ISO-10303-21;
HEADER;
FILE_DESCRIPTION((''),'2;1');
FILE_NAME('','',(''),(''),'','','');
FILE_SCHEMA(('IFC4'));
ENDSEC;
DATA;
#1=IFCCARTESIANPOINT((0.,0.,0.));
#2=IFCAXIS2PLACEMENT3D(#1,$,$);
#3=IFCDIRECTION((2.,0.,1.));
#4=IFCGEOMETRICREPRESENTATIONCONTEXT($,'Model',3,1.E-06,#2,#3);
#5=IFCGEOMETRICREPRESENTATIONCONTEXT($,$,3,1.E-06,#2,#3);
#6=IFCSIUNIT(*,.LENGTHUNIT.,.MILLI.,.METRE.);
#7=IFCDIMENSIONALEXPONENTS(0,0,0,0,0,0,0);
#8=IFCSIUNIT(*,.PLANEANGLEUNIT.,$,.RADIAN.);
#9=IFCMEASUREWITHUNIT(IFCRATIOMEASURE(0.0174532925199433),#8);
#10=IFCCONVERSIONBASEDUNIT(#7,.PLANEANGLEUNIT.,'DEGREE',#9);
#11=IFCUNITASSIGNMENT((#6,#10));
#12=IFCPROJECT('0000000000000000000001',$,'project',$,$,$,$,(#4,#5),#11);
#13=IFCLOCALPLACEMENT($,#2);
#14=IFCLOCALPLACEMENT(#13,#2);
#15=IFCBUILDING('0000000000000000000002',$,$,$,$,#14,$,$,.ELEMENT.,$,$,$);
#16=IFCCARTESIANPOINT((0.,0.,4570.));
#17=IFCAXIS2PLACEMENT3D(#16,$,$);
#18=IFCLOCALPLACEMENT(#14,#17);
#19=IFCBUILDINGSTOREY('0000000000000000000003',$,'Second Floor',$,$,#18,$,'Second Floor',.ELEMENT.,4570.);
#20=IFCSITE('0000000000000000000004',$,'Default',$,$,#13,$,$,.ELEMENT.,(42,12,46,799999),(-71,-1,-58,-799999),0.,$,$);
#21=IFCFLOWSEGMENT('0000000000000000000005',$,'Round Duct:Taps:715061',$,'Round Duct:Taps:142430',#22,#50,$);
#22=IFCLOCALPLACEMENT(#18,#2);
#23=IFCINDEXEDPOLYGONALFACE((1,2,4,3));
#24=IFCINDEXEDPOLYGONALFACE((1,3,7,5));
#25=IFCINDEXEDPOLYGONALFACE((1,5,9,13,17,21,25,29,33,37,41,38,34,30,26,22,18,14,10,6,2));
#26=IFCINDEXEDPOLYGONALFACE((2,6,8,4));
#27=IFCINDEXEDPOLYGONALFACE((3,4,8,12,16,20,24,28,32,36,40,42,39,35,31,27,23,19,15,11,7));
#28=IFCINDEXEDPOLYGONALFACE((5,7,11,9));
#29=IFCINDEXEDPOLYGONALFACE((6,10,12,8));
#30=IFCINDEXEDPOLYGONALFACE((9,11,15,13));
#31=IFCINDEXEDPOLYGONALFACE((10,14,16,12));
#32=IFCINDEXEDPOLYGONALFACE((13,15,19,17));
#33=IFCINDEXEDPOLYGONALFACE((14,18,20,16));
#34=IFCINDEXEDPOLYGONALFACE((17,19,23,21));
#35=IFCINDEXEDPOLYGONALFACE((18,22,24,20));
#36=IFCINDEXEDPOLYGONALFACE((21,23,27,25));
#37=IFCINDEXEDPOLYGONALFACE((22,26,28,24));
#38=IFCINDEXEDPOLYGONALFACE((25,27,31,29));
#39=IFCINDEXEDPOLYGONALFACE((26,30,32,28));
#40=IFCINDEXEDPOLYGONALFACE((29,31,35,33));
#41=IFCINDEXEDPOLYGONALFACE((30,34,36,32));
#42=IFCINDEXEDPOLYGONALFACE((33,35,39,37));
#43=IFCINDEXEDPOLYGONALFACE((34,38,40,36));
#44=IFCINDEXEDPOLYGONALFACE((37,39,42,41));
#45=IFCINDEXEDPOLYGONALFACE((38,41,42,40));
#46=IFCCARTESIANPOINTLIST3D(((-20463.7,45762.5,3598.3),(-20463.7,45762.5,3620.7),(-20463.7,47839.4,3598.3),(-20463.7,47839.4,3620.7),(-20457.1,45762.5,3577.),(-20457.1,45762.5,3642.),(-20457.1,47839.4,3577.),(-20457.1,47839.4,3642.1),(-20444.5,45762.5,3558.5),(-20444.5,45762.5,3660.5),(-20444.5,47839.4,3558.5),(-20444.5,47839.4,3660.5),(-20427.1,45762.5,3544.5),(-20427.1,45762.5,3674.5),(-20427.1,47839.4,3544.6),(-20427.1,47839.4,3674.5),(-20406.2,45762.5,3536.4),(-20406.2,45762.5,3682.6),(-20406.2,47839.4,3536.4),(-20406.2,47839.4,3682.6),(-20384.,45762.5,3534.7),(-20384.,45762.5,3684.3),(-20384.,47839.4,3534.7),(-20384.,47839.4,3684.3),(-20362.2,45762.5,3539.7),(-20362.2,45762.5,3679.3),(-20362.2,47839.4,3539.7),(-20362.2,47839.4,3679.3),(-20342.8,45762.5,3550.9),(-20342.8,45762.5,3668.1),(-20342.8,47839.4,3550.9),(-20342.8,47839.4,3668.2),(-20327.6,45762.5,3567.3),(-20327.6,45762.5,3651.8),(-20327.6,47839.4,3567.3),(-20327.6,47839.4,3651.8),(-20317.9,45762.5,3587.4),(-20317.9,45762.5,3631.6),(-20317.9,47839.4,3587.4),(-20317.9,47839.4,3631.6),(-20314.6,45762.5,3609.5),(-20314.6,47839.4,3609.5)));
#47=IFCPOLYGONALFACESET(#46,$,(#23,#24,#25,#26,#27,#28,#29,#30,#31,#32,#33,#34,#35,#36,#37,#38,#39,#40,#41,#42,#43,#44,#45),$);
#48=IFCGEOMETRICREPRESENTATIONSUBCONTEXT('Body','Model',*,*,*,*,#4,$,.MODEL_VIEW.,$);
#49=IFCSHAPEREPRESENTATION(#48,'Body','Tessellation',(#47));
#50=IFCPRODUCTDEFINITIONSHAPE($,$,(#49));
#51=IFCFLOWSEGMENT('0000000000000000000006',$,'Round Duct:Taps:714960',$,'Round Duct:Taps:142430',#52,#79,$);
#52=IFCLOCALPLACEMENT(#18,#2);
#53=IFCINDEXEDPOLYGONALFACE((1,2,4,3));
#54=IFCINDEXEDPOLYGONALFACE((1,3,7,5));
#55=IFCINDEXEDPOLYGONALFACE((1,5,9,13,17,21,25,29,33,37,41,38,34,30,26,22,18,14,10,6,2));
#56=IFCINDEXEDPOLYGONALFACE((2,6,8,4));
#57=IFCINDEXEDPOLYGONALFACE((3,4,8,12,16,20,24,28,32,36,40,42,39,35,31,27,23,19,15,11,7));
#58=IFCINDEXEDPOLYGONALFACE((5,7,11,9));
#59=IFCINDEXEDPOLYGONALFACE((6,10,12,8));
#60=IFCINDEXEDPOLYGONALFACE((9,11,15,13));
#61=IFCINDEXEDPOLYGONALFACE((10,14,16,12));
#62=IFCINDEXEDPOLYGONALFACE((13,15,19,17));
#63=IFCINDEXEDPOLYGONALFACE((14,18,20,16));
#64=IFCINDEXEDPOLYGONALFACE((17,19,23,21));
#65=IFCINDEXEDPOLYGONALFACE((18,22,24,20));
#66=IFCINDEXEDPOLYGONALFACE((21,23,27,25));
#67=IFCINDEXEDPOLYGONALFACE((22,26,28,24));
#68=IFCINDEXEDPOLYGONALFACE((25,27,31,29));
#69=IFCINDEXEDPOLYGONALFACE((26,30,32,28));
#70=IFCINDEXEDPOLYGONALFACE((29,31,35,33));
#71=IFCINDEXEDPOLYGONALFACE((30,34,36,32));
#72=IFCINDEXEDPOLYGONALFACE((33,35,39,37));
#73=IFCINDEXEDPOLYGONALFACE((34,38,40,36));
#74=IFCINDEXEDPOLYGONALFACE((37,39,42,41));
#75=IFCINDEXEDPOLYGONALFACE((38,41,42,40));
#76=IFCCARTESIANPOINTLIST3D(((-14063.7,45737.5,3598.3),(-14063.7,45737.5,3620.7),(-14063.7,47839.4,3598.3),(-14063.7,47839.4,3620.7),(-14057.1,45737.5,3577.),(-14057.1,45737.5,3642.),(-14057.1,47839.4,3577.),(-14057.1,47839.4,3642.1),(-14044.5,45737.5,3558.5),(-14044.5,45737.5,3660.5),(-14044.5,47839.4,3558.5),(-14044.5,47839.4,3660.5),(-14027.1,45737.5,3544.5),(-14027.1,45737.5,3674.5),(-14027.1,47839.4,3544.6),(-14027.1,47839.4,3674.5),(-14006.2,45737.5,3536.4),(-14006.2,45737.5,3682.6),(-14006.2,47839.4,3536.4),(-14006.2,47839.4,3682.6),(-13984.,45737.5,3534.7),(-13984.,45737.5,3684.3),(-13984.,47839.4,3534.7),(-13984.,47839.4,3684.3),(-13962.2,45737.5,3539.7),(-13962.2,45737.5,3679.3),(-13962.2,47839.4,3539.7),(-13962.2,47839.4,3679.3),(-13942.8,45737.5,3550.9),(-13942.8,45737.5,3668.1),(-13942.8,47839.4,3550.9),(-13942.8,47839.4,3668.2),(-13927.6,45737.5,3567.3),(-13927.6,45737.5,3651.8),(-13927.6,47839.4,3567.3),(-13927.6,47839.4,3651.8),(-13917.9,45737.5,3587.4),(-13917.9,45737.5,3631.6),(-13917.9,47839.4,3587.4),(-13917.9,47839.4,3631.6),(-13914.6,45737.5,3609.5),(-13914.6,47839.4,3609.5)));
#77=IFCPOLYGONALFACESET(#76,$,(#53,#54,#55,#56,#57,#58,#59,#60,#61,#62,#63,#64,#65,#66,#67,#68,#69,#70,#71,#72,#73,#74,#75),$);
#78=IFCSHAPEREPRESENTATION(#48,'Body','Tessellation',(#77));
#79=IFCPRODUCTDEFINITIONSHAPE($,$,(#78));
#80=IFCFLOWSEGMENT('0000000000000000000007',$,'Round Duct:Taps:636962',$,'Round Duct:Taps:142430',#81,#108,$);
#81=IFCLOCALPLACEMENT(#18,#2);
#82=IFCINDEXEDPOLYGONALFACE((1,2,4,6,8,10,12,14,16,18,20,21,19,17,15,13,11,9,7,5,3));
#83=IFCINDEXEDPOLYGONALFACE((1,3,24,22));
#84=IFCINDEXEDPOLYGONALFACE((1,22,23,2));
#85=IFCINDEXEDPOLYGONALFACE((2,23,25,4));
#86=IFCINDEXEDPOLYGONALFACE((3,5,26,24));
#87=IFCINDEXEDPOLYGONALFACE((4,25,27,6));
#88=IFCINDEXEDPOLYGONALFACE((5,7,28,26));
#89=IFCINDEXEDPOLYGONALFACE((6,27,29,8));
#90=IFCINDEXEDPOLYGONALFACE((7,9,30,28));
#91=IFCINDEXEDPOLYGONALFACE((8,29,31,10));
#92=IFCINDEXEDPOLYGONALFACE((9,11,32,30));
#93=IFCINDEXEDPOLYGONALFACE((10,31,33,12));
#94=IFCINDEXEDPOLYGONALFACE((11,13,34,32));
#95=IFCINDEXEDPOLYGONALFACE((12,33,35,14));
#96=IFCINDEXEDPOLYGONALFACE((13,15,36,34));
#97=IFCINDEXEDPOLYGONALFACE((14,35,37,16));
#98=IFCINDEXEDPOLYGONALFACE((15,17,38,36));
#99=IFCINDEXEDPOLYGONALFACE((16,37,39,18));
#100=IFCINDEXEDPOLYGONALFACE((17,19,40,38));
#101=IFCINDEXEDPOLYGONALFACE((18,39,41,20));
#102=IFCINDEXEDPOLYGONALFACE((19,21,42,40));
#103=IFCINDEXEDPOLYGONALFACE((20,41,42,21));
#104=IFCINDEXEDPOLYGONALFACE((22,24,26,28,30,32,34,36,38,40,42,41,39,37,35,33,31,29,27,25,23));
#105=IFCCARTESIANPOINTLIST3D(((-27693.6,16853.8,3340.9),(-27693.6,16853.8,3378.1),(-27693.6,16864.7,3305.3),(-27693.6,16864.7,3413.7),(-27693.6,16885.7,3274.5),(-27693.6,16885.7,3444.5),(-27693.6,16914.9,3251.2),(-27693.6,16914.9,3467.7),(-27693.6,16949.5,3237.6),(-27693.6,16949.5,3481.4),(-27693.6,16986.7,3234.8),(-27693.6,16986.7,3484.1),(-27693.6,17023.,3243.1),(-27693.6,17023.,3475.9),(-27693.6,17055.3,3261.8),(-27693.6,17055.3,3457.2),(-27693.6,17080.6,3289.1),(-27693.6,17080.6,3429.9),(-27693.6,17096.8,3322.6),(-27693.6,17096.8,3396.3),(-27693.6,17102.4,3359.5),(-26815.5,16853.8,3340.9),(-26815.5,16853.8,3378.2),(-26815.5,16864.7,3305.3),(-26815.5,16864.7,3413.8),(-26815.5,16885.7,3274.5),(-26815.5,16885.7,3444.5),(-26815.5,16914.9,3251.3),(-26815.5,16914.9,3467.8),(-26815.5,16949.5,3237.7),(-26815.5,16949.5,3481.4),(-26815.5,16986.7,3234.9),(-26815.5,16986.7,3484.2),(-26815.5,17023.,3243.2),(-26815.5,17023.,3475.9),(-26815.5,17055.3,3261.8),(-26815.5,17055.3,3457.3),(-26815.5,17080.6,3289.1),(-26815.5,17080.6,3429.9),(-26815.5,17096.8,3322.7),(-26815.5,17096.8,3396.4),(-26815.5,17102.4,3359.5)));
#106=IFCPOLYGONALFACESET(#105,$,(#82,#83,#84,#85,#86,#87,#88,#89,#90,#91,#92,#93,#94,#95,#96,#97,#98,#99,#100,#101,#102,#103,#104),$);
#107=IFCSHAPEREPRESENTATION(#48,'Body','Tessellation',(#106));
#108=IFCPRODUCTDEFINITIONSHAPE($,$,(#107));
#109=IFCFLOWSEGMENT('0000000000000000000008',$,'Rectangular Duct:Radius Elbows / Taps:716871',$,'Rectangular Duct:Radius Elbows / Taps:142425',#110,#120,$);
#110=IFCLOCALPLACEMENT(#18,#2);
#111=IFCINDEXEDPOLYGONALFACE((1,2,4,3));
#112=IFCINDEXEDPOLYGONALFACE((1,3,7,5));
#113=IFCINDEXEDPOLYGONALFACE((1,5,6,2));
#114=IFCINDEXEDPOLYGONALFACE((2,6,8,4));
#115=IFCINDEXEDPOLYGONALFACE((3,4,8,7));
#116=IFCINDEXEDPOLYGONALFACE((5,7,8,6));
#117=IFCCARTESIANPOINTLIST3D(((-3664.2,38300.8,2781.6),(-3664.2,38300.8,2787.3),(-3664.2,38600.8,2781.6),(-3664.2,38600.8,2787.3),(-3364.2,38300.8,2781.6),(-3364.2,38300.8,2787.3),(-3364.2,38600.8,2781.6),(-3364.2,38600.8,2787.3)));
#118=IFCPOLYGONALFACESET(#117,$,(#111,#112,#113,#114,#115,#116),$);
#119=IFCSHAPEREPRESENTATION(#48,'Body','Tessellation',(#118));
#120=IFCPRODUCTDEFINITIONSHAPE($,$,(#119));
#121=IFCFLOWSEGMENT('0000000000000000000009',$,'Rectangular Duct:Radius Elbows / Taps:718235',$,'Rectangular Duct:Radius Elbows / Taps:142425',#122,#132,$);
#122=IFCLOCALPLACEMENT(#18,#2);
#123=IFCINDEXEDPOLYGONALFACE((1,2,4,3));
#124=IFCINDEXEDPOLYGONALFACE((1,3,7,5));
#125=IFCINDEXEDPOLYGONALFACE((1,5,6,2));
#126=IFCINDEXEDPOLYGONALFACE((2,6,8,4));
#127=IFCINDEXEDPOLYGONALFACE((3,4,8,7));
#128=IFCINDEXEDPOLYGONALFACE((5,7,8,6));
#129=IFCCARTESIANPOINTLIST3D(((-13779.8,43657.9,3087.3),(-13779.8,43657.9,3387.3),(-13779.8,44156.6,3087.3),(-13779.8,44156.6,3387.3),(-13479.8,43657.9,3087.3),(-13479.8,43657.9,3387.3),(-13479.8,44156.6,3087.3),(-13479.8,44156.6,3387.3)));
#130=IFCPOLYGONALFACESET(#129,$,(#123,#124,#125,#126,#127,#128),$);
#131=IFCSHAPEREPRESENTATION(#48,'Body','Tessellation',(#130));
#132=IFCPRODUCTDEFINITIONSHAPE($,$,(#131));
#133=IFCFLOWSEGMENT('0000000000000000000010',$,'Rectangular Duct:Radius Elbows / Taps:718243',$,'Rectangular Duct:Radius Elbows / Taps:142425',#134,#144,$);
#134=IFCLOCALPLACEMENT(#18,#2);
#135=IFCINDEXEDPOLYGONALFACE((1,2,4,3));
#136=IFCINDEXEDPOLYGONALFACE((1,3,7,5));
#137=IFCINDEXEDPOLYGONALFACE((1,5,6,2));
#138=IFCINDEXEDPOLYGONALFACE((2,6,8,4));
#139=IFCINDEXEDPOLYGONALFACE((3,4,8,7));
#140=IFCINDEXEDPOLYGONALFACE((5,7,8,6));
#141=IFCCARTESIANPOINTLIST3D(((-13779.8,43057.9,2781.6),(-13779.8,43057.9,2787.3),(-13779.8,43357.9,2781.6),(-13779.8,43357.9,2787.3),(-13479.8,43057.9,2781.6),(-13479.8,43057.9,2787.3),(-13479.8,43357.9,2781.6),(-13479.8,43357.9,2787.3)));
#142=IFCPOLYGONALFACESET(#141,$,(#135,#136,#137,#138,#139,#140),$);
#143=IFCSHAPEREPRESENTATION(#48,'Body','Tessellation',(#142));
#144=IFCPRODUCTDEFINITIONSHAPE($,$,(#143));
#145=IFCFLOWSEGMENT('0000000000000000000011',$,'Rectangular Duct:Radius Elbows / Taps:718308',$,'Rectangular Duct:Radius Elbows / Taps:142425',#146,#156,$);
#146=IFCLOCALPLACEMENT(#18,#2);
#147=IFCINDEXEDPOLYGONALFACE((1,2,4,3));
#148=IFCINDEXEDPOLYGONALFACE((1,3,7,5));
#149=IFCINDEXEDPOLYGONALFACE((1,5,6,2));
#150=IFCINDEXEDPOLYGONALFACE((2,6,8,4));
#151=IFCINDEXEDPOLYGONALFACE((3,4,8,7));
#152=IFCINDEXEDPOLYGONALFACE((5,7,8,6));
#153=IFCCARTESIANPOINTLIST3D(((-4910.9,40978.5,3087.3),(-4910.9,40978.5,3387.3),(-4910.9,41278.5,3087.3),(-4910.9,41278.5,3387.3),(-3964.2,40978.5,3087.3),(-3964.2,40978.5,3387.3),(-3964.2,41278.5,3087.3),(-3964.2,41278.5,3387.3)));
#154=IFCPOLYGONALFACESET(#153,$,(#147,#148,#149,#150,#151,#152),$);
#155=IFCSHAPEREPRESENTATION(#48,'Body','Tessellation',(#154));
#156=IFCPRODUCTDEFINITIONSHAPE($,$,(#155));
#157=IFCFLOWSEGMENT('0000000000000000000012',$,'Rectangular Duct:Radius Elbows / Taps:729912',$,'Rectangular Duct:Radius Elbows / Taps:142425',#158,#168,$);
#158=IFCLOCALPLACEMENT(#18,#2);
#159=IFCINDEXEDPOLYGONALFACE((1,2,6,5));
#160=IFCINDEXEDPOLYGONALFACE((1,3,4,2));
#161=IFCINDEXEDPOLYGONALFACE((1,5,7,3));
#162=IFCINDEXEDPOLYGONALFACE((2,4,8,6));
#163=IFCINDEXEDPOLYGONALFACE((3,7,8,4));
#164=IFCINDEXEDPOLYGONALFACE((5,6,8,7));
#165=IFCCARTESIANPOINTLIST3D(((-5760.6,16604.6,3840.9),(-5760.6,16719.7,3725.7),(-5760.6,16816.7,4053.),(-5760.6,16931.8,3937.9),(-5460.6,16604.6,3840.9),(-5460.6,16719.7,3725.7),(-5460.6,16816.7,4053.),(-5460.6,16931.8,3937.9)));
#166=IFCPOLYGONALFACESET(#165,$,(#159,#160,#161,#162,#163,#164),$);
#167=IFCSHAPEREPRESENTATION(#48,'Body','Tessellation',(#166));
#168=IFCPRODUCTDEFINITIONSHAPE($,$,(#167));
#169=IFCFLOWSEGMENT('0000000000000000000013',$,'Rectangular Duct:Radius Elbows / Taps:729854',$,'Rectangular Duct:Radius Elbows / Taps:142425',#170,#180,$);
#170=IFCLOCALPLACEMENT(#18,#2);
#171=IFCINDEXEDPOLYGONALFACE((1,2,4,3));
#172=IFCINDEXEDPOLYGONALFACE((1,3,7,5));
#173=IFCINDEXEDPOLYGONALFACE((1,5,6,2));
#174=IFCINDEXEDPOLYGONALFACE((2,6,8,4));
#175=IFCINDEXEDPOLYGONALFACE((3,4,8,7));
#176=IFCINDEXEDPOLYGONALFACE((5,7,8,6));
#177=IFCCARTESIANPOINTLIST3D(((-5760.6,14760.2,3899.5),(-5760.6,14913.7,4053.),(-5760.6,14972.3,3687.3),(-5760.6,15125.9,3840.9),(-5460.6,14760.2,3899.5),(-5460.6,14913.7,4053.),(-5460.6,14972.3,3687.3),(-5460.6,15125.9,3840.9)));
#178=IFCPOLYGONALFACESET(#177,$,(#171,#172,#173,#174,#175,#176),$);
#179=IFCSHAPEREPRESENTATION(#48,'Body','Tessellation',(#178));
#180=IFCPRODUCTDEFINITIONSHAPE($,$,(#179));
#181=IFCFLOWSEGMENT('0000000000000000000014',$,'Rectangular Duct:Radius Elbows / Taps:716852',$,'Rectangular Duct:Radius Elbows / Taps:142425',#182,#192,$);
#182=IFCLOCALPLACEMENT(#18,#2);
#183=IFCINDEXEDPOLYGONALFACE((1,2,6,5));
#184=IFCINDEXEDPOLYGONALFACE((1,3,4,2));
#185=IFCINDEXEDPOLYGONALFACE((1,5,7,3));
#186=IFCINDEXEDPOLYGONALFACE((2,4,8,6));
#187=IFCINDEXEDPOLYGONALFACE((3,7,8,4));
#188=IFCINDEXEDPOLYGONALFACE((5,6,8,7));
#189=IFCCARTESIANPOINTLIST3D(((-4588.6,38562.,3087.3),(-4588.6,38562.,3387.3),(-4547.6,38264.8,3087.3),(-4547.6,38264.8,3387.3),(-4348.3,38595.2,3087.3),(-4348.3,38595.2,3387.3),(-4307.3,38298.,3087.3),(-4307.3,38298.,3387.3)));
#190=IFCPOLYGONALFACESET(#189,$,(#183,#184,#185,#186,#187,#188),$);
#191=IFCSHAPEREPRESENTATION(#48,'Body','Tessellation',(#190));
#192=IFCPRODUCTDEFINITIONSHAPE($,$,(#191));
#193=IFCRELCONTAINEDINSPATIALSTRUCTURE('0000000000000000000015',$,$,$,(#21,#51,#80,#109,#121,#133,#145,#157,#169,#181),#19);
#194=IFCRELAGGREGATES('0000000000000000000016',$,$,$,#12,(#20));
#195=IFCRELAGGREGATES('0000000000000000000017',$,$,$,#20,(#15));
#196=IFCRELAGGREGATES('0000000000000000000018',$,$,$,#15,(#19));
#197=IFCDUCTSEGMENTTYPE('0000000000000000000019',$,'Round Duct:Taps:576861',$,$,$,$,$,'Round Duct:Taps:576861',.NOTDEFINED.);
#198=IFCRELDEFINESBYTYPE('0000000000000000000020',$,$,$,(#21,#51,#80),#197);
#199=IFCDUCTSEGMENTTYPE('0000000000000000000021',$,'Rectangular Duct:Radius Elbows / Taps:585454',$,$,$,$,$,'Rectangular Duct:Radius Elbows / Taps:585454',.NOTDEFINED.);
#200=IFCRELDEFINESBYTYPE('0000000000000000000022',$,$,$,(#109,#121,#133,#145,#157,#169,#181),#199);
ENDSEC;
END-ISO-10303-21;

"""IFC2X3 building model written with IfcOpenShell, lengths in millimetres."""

from ifc_helpers import new_model, entity, si_unit, converted_unit, direction, frame, frame_2d, origin, origin_2d_with_axis, place, context, subcontext, project, spatial, rectangle, circle, extrude, type_object, element, save


model = new_model("IFC2X3")

# Units and contexts
model_context = context("Model", 3, precision=1e-06, world=origin(), true_north=direction((2.0, 0.0, 1.0)))
context_of_model = context(None, 3, precision=1e-06, world=origin(), true_north=direction((2.0, 0.0, 1.0)))
body_context = subcontext(model_context, "Body", "Model", "MODEL_VIEW")
ifc_project = project(units=[si_unit("LENGTHUNIT", "METRE", prefix="MILLI"), converted_unit("PLANEANGLEUNIT", "DEGREE", entity("IfcRatioMeasure", 0.0174532925199433), si_unit("PLANEANGLEUNIT", "RADIAN"), dimensions=[0, 0, 0, 0, 0, 0, 0])], contexts=[model_context, context_of_model])

# Site, building, storey
site_placement = place(None, origin())
site = spatial("IfcSite", under=ifc_project, at=site_placement, Name="Default", CompositionType="ELEMENT", RefLatitude=(42, 12, 46, 799999), RefLongitude=(-71, -1, -58, -799999), RefElevation=0.0)
building_placement = place(site_placement, origin())
building = spatial("IfcBuilding", under=site, at=building_placement, CompositionType="ELEMENT")
storey_placement = place(building_placement, frame((0.0, 0.0, 4570.0)))
storey = spatial("IfcBuildingStorey", under=building, at=storey_placement, Name="Second Floor", LongName="Second Floor", CompositionType="ELEMENT", Elevation=4570.0)

# Flow segments
duct_segment_type_1 = type_object("IfcDuctSegmentType", Name="Round Duct:Taps:576861", ElementType="Round Duct:Taps:576861", PredefinedType="NOTDEFINED")
flow_segment_1_placement = place(storey_placement, origin())
element("IfcFlowSegment", 1, at=flow_segment_1_placement, inside=storey, type_object=duct_segment_type_1, Name="Round Duct:Taps:715061", ObjectType="Round Duct:Taps:142430", context=body_context, shape_type="SweptSolid", body=[
    extrude(circle(Radius=75.0, at=origin_2d_with_axis()), frame((-20389.6, 45762.5, 3609.5), z_axis=(0.0, 1.0, 0.000011), x_axis=(1.0, 0.0, 0.0)), (0.0, 0.0, 1.0), 2077.0),
])
flow_segment_2_placement = place(storey_placement, origin())
element("IfcFlowSegment", 2, at=flow_segment_2_placement, inside=storey, type_object=duct_segment_type_1, Name="Round Duct:Taps:714960", ObjectType="Round Duct:Taps:142430", context=body_context, shape_type="SweptSolid", body=[
    extrude(circle(Radius=75.0, at=origin_2d_with_axis()), frame((-13989.6, 45737.5, 3609.5), z_axis=(0.0, 1.0, 0.000011), x_axis=(1.0, 0.0, 0.0)), (0.0, 0.0, 1.0), 2102.0),
])
flow_segment_3_placement = place(storey_placement, origin())
element("IfcFlowSegment", 3, at=flow_segment_3_placement, inside=storey, type_object=duct_segment_type_1, Name="Round Duct:Taps:636962", ObjectType="Round Duct:Taps:142430", context=body_context, shape_type="SweptSolid", body=[
    extrude(circle(Radius=125.0, at=frame_2d((0.0, 0.0), x_axis=(1.0, 0.0))), frame((-27693.6, 16977.4, 3359.5), z_axis=(1.0, 0.0, 0.000036), x_axis=(0.0, 1.0, 0.0)), (0.0, 0.0, 1.0), 878.2),
])
duct_segment_type_2 = type_object("IfcDuctSegmentType", Name="Rectangular Duct:Radius Elbows / Taps:585454", ElementType="Rectangular Duct:Radius Elbows / Taps:585454", PredefinedType="NOTDEFINED")
flow_segment_4_placement = place(storey_placement, origin())
element("IfcFlowSegment", 4, at=flow_segment_4_placement, inside=storey, type_object=duct_segment_type_2, Name="Rectangular Duct:Radius Elbows / Taps:716871", ObjectType="Rectangular Duct:Radius Elbows / Taps:142425", context=body_context, shape_type="SweptSolid", body=[
    extrude(rectangle(XDim=300.0, YDim=300.0, at=origin_2d_with_axis()), frame((-3514.2, 38450.8, 2781.6)), (0.0, 0.0, 1.0), 5.7),
])
flow_segment_5_placement = place(storey_placement, origin())
element("IfcFlowSegment", 5, at=flow_segment_5_placement, inside=storey, type_object=duct_segment_type_2, Name="Rectangular Duct:Radius Elbows / Taps:718235", ObjectType="Rectangular Duct:Radius Elbows / Taps:142425", context=body_context, shape_type="SweptSolid", body=[
    extrude(rectangle(XDim=498.7, YDim=300.0, at=frame_2d((0.0, 0.0), x_axis=(1.0, 0.0))), frame((-13629.8, 43907.3, 3087.3), z_axis=(0.0, 0.0, 1.0), x_axis=(0.0, 1.0, 0.0)), (0.0, 0.0, 1.0), 300.0),
])
flow_segment_6_placement = place(storey_placement, origin())
element("IfcFlowSegment", 6, at=flow_segment_6_placement, inside=storey, type_object=duct_segment_type_2, Name="Rectangular Duct:Radius Elbows / Taps:718243", ObjectType="Rectangular Duct:Radius Elbows / Taps:142425", context=body_context, shape_type="SweptSolid", body=[
    extrude(rectangle(XDim=300.0, YDim=300.0, at=origin_2d_with_axis()), frame((-13629.8, 43207.9, 2781.6), z_axis=(0.0, 0.0, 1.0), x_axis=(0.0, -1.0, 0.0)), (0.0, 0.0, 1.0), 5.7),
])
flow_segment_7_placement = place(storey_placement, origin())
element("IfcFlowSegment", 7, at=flow_segment_7_placement, inside=storey, type_object=duct_segment_type_2, Name="Rectangular Duct:Radius Elbows / Taps:718308", ObjectType="Rectangular Duct:Radius Elbows / Taps:142425", context=body_context, shape_type="SweptSolid", body=[
    extrude(rectangle(XDim=946.7, YDim=300.0, at=frame_2d((0.0, 0.0), x_axis=(1.0, 0.0))), frame((-4437.5, 41128.5, 3087.3), z_axis=(0.0, 0.0, 1.0), x_axis=(-1.0, 0.0, 0.0)), (0.0, 0.0, 1.0), 300.0),
])
flow_segment_8_placement = place(storey_placement, origin())
element("IfcFlowSegment", 8, at=flow_segment_8_placement, inside=storey, type_object=duct_segment_type_2, Name="Rectangular Duct:Radius Elbows / Taps:729912", ObjectType="Rectangular Duct:Radius Elbows / Taps:142425", context=body_context, shape_type="SweptSolid", body=[
    extrude(rectangle(XDim=162.8, YDim=300.0, at=frame_2d((0.0, 0.0), x_axis=(1.0, 0.0))), frame((-5760.6, 16768.2, 3889.4), z_axis=(1.0, 0.0, 0.0), x_axis=(0.0, 0.707107, -0.707107)), (0.0, 0.0, 1.0), 300.0),
])
flow_segment_9_placement = place(storey_placement, origin())
element("IfcFlowSegment", 9, at=flow_segment_9_placement, inside=storey, type_object=duct_segment_type_2, Name="Rectangular Duct:Radius Elbows / Taps:729854", ObjectType="Rectangular Duct:Radius Elbows / Taps:142425", context=body_context, shape_type="SweptSolid", body=[
    extrude(rectangle(XDim=217.1, YDim=300.0, at=frame_2d((0.0, 0.0), x_axis=(1.0, 0.0))), frame((-5760.6, 14943.0, 3870.2), z_axis=(1.0, 0.0, 0.0), x_axis=(0.0, 0.707107, 0.707107)), (0.0, 0.0, 1.0), 300.0),
])
flow_segment_10_placement = place(storey_placement, origin())
element("IfcFlowSegment", 10, at=flow_segment_10_placement, inside=storey, type_object=duct_segment_type_2, Name="Rectangular Duct:Radius Elbows / Taps:716852", ObjectType="Rectangular Duct:Radius Elbows / Taps:142425", context=body_context, shape_type="SweptSolid", body=[
    extrude(rectangle(XDim=242.5, YDim=300.0, at=frame_2d((0.0, 0.0), x_axis=(1.0, 0.0))), frame((-4448.0, 38430.0, 3087.3), z_axis=(0.0, 0.0, 1.0), x_axis=(-0.990618, -0.136659, 0.0)), (0.0, 0.0, 1.0), 300.0),
])

save(model, "model.ifc")
